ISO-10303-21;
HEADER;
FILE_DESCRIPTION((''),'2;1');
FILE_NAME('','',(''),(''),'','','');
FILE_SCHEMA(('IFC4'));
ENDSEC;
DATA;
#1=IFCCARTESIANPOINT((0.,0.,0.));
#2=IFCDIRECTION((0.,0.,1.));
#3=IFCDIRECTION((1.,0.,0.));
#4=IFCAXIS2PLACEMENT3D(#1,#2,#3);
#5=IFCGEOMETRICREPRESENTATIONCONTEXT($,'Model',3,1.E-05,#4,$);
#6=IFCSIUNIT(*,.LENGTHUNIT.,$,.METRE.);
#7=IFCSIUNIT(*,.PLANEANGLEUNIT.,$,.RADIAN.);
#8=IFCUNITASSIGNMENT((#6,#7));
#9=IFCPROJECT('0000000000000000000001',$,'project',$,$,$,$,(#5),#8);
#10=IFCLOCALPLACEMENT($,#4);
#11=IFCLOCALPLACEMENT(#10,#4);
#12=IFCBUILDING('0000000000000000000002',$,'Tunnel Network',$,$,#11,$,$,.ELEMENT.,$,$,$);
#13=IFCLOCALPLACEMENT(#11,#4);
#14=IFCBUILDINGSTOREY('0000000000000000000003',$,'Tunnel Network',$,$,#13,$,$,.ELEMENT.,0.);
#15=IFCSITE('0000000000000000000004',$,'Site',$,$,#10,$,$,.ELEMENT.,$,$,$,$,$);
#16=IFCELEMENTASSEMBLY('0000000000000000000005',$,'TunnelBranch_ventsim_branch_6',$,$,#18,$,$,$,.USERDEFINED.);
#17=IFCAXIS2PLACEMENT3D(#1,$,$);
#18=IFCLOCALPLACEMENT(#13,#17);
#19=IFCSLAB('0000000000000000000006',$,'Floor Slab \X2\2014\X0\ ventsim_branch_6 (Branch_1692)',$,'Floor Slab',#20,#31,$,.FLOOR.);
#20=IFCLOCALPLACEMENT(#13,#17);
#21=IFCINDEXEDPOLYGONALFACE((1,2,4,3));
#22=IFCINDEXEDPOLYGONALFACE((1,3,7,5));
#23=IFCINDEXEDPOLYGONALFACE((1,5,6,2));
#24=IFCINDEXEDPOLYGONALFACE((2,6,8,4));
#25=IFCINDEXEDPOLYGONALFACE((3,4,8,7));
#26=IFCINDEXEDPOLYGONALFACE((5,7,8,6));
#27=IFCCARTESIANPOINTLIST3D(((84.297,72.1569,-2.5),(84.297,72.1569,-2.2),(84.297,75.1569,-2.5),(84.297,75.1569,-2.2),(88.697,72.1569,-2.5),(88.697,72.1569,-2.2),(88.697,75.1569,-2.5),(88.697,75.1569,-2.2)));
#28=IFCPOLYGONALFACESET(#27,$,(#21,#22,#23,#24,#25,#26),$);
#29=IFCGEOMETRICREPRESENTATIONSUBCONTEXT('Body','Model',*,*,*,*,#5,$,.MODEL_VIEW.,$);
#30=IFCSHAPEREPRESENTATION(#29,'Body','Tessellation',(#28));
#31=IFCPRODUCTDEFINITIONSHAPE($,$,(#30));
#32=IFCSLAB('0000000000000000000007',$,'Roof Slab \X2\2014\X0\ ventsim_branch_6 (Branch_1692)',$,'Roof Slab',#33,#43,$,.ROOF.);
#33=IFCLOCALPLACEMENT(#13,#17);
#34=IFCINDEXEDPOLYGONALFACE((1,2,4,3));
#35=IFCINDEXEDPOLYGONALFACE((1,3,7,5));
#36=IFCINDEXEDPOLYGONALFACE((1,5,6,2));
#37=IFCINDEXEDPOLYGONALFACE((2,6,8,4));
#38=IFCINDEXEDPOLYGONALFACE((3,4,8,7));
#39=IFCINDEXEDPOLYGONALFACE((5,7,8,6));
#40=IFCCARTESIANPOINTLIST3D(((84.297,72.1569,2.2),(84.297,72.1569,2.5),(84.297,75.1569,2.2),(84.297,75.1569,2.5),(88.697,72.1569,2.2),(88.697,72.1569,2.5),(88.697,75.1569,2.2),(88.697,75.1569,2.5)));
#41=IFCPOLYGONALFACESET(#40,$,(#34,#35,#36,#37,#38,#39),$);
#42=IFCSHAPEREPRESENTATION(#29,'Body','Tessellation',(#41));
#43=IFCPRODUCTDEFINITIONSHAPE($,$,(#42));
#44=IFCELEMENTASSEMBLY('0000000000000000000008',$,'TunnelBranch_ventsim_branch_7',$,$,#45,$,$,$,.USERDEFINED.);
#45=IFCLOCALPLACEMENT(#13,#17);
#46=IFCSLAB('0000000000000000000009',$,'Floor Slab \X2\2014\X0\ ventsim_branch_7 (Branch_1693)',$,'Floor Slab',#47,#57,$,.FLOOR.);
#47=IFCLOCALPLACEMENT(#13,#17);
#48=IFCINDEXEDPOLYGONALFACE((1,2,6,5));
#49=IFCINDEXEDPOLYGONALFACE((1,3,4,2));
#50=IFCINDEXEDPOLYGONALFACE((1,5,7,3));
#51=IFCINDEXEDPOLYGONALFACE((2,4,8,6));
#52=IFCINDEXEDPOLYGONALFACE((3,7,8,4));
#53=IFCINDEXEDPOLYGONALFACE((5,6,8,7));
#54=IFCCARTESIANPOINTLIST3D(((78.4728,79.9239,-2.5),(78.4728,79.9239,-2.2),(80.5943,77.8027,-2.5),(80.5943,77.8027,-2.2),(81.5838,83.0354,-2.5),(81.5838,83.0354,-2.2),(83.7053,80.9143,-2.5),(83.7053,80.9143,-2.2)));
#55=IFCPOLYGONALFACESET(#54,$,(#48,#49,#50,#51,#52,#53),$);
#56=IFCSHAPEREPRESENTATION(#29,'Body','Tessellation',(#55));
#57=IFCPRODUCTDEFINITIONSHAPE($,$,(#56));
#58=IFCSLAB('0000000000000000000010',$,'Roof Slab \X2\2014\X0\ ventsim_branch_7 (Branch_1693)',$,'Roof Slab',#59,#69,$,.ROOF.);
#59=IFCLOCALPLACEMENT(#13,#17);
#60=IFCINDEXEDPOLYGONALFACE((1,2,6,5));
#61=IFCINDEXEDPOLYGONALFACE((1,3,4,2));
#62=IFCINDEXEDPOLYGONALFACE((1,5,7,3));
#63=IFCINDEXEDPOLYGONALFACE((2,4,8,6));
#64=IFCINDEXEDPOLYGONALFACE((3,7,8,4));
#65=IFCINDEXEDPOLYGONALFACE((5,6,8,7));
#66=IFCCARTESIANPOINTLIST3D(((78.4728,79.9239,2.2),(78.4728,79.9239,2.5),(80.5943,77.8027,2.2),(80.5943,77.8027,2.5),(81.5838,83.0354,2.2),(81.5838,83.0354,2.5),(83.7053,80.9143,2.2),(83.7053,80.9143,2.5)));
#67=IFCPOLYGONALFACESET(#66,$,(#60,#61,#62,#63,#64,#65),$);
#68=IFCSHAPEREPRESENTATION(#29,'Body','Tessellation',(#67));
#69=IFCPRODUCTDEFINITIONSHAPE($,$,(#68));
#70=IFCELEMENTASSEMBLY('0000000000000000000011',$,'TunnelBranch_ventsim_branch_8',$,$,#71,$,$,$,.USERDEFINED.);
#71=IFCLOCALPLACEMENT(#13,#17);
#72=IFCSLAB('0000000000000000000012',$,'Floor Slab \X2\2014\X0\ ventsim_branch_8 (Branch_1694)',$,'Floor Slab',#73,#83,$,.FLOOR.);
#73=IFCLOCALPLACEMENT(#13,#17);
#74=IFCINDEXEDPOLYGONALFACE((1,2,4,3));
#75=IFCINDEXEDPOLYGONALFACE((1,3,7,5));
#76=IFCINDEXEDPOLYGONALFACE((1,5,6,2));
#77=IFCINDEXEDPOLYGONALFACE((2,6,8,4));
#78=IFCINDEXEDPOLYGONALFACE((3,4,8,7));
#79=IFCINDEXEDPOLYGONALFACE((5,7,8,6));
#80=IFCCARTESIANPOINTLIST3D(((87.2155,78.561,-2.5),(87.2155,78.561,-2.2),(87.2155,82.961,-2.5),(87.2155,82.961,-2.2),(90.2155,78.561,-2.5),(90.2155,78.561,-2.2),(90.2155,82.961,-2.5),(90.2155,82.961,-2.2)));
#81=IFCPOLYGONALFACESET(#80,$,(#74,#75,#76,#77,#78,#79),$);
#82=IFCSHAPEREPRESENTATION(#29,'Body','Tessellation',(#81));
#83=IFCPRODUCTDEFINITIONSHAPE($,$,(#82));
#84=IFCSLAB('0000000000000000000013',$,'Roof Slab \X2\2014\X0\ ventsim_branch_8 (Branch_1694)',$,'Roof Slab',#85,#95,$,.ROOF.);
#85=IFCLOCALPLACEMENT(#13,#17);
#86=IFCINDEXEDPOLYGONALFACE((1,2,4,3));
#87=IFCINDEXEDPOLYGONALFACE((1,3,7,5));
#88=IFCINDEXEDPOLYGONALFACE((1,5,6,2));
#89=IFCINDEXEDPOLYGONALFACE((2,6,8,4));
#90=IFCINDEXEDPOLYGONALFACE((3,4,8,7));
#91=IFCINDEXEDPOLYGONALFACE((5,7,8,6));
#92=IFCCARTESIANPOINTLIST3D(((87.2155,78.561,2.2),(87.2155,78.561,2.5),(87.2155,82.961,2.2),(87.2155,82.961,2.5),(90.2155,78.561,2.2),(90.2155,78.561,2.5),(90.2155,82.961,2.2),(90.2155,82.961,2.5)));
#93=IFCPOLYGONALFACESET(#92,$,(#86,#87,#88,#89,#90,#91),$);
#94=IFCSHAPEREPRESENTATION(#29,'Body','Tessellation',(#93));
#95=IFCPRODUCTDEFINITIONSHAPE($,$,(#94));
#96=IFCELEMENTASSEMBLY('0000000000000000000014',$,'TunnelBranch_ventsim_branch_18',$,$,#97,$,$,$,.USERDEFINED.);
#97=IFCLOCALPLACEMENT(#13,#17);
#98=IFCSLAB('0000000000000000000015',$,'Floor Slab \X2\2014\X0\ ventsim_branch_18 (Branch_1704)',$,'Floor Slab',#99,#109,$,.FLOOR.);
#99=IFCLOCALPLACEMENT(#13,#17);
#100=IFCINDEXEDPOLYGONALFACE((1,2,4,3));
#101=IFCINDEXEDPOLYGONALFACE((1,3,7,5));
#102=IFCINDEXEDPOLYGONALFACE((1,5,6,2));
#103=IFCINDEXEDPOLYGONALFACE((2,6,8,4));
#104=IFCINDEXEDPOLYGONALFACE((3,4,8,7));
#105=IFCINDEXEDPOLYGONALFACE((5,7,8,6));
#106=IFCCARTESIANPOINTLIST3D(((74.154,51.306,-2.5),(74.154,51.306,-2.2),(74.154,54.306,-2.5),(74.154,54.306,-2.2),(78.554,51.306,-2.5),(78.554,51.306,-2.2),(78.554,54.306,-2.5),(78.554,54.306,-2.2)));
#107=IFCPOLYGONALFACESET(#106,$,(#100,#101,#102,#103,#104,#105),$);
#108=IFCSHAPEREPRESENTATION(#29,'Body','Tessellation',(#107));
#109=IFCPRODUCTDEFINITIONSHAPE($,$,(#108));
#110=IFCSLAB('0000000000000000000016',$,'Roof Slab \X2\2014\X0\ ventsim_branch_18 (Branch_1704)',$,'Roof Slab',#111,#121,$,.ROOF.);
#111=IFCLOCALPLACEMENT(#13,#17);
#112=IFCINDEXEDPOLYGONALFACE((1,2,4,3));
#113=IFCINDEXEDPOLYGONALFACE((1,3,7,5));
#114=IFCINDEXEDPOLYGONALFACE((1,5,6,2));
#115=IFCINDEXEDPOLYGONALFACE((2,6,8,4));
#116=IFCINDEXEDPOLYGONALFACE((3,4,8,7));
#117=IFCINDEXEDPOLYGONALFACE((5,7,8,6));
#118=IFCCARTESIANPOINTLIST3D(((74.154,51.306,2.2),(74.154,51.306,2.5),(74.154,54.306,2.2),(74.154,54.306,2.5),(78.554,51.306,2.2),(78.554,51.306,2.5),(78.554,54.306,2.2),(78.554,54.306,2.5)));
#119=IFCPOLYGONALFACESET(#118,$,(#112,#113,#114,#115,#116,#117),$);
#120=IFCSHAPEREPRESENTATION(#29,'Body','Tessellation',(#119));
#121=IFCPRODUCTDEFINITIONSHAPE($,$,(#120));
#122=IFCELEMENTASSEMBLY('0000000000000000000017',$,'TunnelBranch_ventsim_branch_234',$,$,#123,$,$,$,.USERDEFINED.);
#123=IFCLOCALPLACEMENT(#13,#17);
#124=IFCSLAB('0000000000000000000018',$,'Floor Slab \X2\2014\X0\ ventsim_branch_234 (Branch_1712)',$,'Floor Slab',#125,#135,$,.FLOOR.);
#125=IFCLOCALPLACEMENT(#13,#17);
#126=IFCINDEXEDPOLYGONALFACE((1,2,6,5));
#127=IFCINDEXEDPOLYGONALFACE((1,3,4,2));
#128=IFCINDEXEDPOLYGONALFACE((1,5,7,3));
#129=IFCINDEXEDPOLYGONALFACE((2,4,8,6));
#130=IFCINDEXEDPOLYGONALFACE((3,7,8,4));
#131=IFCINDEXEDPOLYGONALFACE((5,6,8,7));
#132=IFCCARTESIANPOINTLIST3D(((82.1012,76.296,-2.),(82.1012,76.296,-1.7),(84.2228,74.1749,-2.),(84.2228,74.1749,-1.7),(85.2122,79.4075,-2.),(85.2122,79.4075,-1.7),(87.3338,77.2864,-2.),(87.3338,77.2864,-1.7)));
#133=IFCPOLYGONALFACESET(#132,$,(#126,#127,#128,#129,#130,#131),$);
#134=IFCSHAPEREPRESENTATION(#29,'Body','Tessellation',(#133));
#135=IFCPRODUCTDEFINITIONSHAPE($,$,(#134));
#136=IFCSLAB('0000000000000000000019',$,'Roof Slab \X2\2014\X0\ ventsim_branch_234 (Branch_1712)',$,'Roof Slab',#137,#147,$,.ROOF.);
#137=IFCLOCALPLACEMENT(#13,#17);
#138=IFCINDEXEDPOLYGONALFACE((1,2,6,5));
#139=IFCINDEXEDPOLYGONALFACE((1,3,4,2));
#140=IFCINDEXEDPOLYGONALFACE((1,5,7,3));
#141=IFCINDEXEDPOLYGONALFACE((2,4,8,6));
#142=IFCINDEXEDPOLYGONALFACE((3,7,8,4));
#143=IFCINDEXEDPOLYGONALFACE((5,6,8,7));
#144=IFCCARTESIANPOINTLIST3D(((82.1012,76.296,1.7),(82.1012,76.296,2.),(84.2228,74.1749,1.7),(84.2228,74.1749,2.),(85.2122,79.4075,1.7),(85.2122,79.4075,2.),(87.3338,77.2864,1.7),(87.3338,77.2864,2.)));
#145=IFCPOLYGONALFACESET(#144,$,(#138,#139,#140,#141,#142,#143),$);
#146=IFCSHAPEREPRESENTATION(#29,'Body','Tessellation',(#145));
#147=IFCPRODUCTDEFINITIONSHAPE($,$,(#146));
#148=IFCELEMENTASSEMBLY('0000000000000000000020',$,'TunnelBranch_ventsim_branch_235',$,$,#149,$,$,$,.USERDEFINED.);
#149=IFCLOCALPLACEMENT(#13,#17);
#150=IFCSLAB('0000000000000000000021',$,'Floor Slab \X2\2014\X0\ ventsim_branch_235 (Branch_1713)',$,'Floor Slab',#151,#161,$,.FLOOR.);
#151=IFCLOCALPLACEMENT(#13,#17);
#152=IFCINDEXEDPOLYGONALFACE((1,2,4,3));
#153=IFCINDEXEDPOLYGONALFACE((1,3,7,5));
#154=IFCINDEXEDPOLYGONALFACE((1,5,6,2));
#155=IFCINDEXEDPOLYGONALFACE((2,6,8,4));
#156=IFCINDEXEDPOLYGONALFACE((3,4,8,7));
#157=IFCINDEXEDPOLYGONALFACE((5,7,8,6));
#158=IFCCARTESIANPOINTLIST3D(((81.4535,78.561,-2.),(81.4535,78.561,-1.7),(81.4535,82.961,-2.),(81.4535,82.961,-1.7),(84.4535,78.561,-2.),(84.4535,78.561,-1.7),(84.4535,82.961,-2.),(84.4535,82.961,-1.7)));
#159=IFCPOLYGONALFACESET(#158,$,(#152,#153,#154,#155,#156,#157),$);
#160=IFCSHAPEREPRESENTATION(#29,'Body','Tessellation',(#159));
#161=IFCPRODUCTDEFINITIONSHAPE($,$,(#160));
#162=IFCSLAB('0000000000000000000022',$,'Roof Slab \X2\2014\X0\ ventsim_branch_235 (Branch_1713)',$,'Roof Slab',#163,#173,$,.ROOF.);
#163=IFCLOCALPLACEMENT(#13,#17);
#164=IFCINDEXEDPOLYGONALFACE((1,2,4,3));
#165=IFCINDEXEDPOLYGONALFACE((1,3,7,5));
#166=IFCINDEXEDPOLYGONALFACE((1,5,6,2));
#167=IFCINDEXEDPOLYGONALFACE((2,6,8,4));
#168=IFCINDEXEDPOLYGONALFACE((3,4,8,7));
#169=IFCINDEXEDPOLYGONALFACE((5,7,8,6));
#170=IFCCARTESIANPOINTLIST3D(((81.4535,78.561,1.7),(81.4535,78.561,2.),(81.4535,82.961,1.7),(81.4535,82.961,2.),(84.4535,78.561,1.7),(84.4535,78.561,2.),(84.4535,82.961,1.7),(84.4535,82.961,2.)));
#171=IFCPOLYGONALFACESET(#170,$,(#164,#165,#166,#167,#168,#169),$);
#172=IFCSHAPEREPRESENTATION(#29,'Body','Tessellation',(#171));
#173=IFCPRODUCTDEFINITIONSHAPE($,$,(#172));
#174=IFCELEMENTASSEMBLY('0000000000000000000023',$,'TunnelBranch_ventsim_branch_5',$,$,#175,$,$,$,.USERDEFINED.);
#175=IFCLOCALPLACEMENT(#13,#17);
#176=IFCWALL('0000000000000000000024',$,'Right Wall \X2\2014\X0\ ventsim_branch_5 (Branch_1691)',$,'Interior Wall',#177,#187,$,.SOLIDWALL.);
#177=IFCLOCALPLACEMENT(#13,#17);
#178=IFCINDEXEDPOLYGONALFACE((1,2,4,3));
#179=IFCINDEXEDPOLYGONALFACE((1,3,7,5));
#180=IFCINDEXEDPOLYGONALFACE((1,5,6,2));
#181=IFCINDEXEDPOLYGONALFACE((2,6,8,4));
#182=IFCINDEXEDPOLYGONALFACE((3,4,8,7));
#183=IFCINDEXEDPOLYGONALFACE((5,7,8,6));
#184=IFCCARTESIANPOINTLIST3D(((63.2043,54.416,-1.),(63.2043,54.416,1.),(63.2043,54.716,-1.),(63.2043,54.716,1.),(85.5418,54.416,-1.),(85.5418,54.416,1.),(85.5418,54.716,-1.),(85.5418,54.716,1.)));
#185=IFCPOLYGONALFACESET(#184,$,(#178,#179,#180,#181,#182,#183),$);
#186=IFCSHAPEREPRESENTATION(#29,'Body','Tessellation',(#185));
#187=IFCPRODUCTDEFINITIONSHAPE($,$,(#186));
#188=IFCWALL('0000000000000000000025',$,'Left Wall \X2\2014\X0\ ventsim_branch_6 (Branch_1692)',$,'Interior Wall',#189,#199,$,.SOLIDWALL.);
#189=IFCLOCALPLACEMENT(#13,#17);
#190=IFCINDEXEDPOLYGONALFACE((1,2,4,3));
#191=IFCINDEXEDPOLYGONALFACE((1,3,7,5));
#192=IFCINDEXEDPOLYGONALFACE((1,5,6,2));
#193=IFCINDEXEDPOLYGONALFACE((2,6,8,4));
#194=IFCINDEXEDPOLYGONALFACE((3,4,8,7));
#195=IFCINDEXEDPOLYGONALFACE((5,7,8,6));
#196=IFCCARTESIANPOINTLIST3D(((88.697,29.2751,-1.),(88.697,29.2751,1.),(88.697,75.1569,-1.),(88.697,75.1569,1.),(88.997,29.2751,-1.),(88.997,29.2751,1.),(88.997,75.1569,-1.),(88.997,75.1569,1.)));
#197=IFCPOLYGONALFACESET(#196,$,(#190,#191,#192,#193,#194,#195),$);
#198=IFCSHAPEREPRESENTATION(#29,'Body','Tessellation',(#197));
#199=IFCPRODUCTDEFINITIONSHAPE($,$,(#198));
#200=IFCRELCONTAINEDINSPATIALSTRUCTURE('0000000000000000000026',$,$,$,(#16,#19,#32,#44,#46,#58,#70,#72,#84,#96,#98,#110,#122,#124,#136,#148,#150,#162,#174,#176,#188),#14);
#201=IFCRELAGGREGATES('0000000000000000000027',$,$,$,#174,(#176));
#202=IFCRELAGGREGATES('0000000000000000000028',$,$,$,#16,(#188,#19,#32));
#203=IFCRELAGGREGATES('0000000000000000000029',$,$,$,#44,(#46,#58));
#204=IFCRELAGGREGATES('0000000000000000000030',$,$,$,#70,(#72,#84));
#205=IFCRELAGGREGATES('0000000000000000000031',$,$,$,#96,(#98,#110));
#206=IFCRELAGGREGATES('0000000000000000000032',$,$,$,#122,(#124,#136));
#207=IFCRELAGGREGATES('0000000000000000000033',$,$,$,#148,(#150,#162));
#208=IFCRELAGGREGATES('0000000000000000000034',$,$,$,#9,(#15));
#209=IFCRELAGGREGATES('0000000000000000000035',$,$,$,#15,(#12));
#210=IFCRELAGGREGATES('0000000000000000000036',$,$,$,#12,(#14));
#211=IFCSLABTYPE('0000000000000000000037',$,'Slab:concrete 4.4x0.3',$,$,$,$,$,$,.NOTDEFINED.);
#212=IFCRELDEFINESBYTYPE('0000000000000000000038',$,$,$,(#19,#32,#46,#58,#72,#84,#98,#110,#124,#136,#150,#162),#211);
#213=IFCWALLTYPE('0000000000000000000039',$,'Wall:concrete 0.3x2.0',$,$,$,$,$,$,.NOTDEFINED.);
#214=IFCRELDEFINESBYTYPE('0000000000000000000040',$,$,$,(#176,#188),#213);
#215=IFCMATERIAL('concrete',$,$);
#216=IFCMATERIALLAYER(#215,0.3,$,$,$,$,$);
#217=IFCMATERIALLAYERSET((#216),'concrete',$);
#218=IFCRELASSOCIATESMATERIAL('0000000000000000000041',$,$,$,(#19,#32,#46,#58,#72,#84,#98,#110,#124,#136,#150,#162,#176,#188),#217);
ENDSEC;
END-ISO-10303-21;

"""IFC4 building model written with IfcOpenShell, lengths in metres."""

from ifc_helpers import new_model, si_unit, frame, origin_with_axes, origin_2d_with_axis, place, context, subcontext, project, spatial, rectangle, extrude, material, layer, layer_set, layer_usage, type_object, element, aggregate, save


model = new_model("IFC4")

# Units and contexts
model_context = context("Model", 3, precision=1e-05, world=origin_with_axes())
body_context = subcontext(model_context, "Body", "Model", "MODEL_VIEW")
ifc_project = project(units=[si_unit("LENGTHUNIT", "METRE"), si_unit("PLANEANGLEUNIT", "RADIAN")], contexts=[model_context])

# Site, building, storey
site_placement = place(None, origin_with_axes())
site = spatial("IfcSite", under=ifc_project, at=site_placement, Name="Site", CompositionType="ELEMENT")
building_placement = place(site_placement, origin_with_axes())
building = spatial("IfcBuilding", under=site, at=building_placement, Name="Tunnel Network", CompositionType="ELEMENT")
storey_placement = place(building_placement, origin_with_axes())
storey = spatial("IfcBuildingStorey", under=building, at=storey_placement, Name="Tunnel Network", CompositionType="ELEMENT", Elevation=0.0)

# Element assemblies, slabs
assembly_1_placement = place(storey_placement, frame((88.847, 75.1569, 0.0), z_axis=(0.0, -1.0, 0.0), x_axis=(-1.0, 0.0, 0.0)))
assembly_1 = element("IfcElementAssembly", 1, at=assembly_1_placement, inside=storey, Name="TunnelBranch_ventsim_branch_6", PredefinedType="USERDEFINED")
ifc_material = material(Name="concrete")
ifc_layer = layer(ifc_material, 0.3)
ifc_layer_set = layer_set([ifc_layer], Name="concrete")
ifc_layer_usage_1 = layer_usage(ifc_layer_set, "AXIS3", "POSITIVE", 0.0)
slab_type = type_object("IfcSlabType", Name="Slab:concrete 4.4x0.3")
slab_1_placement = place(storey_placement, frame((86.497, 75.1569, -2.35), z_axis=(0.0, -1.0, 0.0), x_axis=(-1.0, 0.0, 0.0)))
slab_1 = element("IfcSlab", 2, at=slab_1_placement, inside=storey, type_object=slab_type, material=ifc_layer_usage_1, Name="Floor Slab — ventsim_branch_6 (Branch_1692)", ObjectType="Floor Slab", PredefinedType="FLOOR", context=body_context, shape_type="SweptSolid", body=[
    extrude(rectangle(XDim=4.4, YDim=0.3, at=origin_2d_with_axis()), origin_with_axes(), (0.0, 0.0, 1.0), 3.0),
])
ifc_layer_usage_2 = layer_usage(ifc_layer_set, "AXIS3", "POSITIVE", 0.0)
slab_2_placement = place(storey_placement, frame((86.497, 75.1569, 2.35), z_axis=(0.0, -1.0, 0.0), x_axis=(-1.0, 0.0, 0.0)))
slab_2 = element("IfcSlab", 3, at=slab_2_placement, inside=storey, type_object=slab_type, material=ifc_layer_usage_2, Name="Roof Slab — ventsim_branch_6 (Branch_1692)", ObjectType="Roof Slab", PredefinedType="ROOF", context=body_context, shape_type="SweptSolid", body=[
    extrude(rectangle(XDim=4.4, YDim=0.3, at=origin_2d_with_axis()), origin_with_axes(), (0.0, 0.0, 1.0), 3.0),
])
assembly_2_placement = place(storey_placement, frame((81.6898, 83.1415, 0.0), z_axis=(0.707168, -0.707045, 0.0), x_axis=(-0.707045, -0.707168, 0.0)))
assembly_2 = element("IfcElementAssembly", 4, at=assembly_2_placement, inside=storey, Name="TunnelBranch_ventsim_branch_7", PredefinedType="USERDEFINED")
ifc_layer_usage_3 = layer_usage(ifc_layer_set, "AXIS3", "POSITIVE", 0.0)
slab_3_placement = place(storey_placement, frame((80.0283, 81.4796, -2.35), z_axis=(0.707168, -0.707045, 0.0), x_axis=(-0.707045, -0.707168, 0.0)))
slab_3 = element("IfcSlab", 5, at=slab_3_placement, inside=storey, type_object=slab_type, material=ifc_layer_usage_3, Name="Floor Slab — ventsim_branch_7 (Branch_1693)", ObjectType="Floor Slab", PredefinedType="FLOOR", context=body_context, shape_type="SweptSolid", body=[
    extrude(rectangle(XDim=4.4, YDim=0.3, at=origin_2d_with_axis()), origin_with_axes(), (0.0, 0.0, 1.0), 3.0),
])
ifc_layer_usage_4 = layer_usage(ifc_layer_set, "AXIS3", "POSITIVE", 0.0)
slab_4_placement = place(storey_placement, frame((80.0283, 81.4796, 2.35), z_axis=(0.707168, -0.707045, 0.0), x_axis=(-0.707045, -0.707168, 0.0)))
slab_4 = element("IfcSlab", 6, at=slab_4_placement, inside=storey, type_object=slab_type, material=ifc_layer_usage_4, Name="Roof Slab — ventsim_branch_7 (Branch_1693)", ObjectType="Roof Slab", PredefinedType="ROOF", context=body_context, shape_type="SweptSolid", body=[
    extrude(rectangle(XDim=4.4, YDim=0.3, at=origin_2d_with_axis()), origin_with_axes(), (0.0, 0.0, 1.0), 3.0),
])
assembly_3_placement = place(storey_placement, frame((89.9661, 78.411, 0.0), z_axis=(-1.0, 0.0, 0.0), x_axis=(0.0, 1.0, 0.0)))
assembly_3 = element("IfcElementAssembly", 7, at=assembly_3_placement, inside=storey, Name="TunnelBranch_ventsim_branch_8", PredefinedType="USERDEFINED")
ifc_layer_usage_5 = layer_usage(ifc_layer_set, "AXIS3", "POSITIVE", 0.0)
slab_5_placement = place(storey_placement, frame((90.2155, 80.761, -2.35), z_axis=(-1.0, 0.0, 0.0), x_axis=(0.0, 1.0, 0.0)))
slab_5 = element("IfcSlab", 8, at=slab_5_placement, inside=storey, type_object=slab_type, material=ifc_layer_usage_5, Name="Floor Slab — ventsim_branch_8 (Branch_1694)", ObjectType="Floor Slab", PredefinedType="FLOOR", context=body_context, shape_type="SweptSolid", body=[
    extrude(rectangle(XDim=4.4, YDim=0.3, at=origin_2d_with_axis()), origin_with_axes(), (0.0, 0.0, 1.0), 3.0),
])
ifc_layer_usage_6 = layer_usage(ifc_layer_set, "AXIS3", "POSITIVE", 0.0)
slab_6_placement = place(storey_placement, frame((90.2155, 80.761, 2.35), z_axis=(-1.0, 0.0, 0.0), x_axis=(0.0, 1.0, 0.0)))
slab_6 = element("IfcSlab", 9, at=slab_6_placement, inside=storey, type_object=slab_type, material=ifc_layer_usage_6, Name="Roof Slab — ventsim_branch_8 (Branch_1694)", ObjectType="Roof Slab", PredefinedType="ROOF", context=body_context, shape_type="SweptSolid", body=[
    extrude(rectangle(XDim=4.4, YDim=0.3, at=origin_2d_with_axis()), origin_with_axes(), (0.0, 0.0, 1.0), 3.0),
])
assembly_4_placement = place(storey_placement, frame((78.704, 54.306, 0.0), z_axis=(0.0, -1.0, 0.0), x_axis=(-1.0, 0.0, 0.0)))
assembly_4 = element("IfcElementAssembly", 10, at=assembly_4_placement, inside=storey, Name="TunnelBranch_ventsim_branch_18", PredefinedType="USERDEFINED")
ifc_layer_usage_7 = layer_usage(ifc_layer_set, "AXIS3", "POSITIVE", 0.0)
slab_7_placement = place(storey_placement, frame((76.354, 54.306, -2.35), z_axis=(0.0, -1.0, 0.0), x_axis=(-1.0, 0.0, 0.0)))
slab_7 = element("IfcSlab", 11, at=slab_7_placement, inside=storey, type_object=slab_type, material=ifc_layer_usage_7, Name="Floor Slab — ventsim_branch_18 (Branch_1704)", ObjectType="Floor Slab", PredefinedType="FLOOR", context=body_context, shape_type="SweptSolid", body=[
    extrude(rectangle(XDim=4.4, YDim=0.3, at=origin_2d_with_axis()), origin_with_axes(), (0.0, 0.0, 1.0), 3.0),
])
ifc_layer_usage_8 = layer_usage(ifc_layer_set, "AXIS3", "POSITIVE", 0.0)
slab_8_placement = place(storey_placement, frame((76.354, 54.306, 2.35), z_axis=(0.0, -1.0, 0.0), x_axis=(-1.0, 0.0, 0.0)))
slab_8 = element("IfcSlab", 12, at=slab_8_placement, inside=storey, type_object=slab_type, material=ifc_layer_usage_8, Name="Roof Slab — ventsim_branch_18 (Branch_1704)", ObjectType="Roof Slab", PredefinedType="ROOF", context=body_context, shape_type="SweptSolid", body=[
    extrude(rectangle(XDim=4.4, YDim=0.3, at=origin_2d_with_axis()), origin_with_axes(), (0.0, 0.0, 1.0), 3.0),
])
assembly_5_placement = place(storey_placement, frame((84.1167, 74.0688, 0.0), z_axis=(-0.707168, 0.707045, 0.0), x_axis=(0.707045, 0.707168, 0.0)))
assembly_5 = element("IfcElementAssembly", 13, at=assembly_5_placement, inside=storey, Name="TunnelBranch_ventsim_branch_234", PredefinedType="USERDEFINED")
ifc_layer_usage_9 = layer_usage(ifc_layer_set, "AXIS3", "POSITIVE", 0.0)
slab_9_placement = place(storey_placement, frame((85.7783, 75.7306, -1.85), z_axis=(-0.707168, 0.707045, 0.0), x_axis=(0.707045, 0.707168, 0.0)))
slab_9 = element("IfcSlab", 14, at=slab_9_placement, inside=storey, type_object=slab_type, material=ifc_layer_usage_9, Name="Floor Slab — ventsim_branch_234 (Branch_1712)", ObjectType="Floor Slab", PredefinedType="FLOOR", context=body_context, shape_type="SweptSolid", body=[
    extrude(rectangle(XDim=4.4, YDim=0.3, at=origin_2d_with_axis()), origin_with_axes(), (0.0, 0.0, 1.0), 3.0),
])
ifc_layer_usage_10 = layer_usage(ifc_layer_set, "AXIS3", "POSITIVE", 0.0)
slab_10_placement = place(storey_placement, frame((85.7783, 75.7306, 1.85), z_axis=(-0.707168, 0.707045, 0.0), x_axis=(0.707045, 0.707168, 0.0)))
slab_10 = element("IfcSlab", 15, at=slab_10_placement, inside=storey, type_object=slab_type, material=ifc_layer_usage_10, Name="Roof Slab — ventsim_branch_234 (Branch_1712)", ObjectType="Roof Slab", PredefinedType="ROOF", context=body_context, shape_type="SweptSolid", body=[
    extrude(rectangle(XDim=4.4, YDim=0.3, at=origin_2d_with_axis()), origin_with_axes(), (0.0, 0.0, 1.0), 3.0),
])
assembly_6_placement = place(storey_placement, frame((84.5586, 78.411, 0.0), z_axis=(-1.0, 0.0, 0.0), x_axis=(0.0, 1.0, 0.0)))
assembly_6 = element("IfcElementAssembly", 16, at=assembly_6_placement, inside=storey, Name="TunnelBranch_ventsim_branch_235", PredefinedType="USERDEFINED")
ifc_layer_usage_11 = layer_usage(ifc_layer_set, "AXIS3", "POSITIVE", 0.0)
slab_11_placement = place(storey_placement, frame((84.4535, 80.761, -1.85), z_axis=(-1.0, 0.0, 0.0), x_axis=(0.0, 1.0, 0.0)))
slab_11 = element("IfcSlab", 17, at=slab_11_placement, inside=storey, type_object=slab_type, material=ifc_layer_usage_11, Name="Floor Slab — ventsim_branch_235 (Branch_1713)", ObjectType="Floor Slab", PredefinedType="FLOOR", context=body_context, shape_type="SweptSolid", body=[
    extrude(rectangle(XDim=4.4, YDim=0.3, at=origin_2d_with_axis()), origin_with_axes(), (0.0, 0.0, 1.0), 3.0),
])
ifc_layer_usage_12 = layer_usage(ifc_layer_set, "AXIS3", "POSITIVE", 0.0)
slab_12_placement = place(storey_placement, frame((84.4535, 80.761, 1.85), z_axis=(-1.0, 0.0, 0.0), x_axis=(0.0, 1.0, 0.0)))
slab_12 = element("IfcSlab", 18, at=slab_12_placement, inside=storey, type_object=slab_type, material=ifc_layer_usage_12, Name="Roof Slab — ventsim_branch_235 (Branch_1713)", ObjectType="Roof Slab", PredefinedType="ROOF", context=body_context, shape_type="SweptSolid", body=[
    extrude(rectangle(XDim=4.4, YDim=0.3, at=origin_2d_with_axis()), origin_with_axes(), (0.0, 0.0, 1.0), 3.0),
])

# Element assembly, wall
assembly_7_placement = place(storey_placement, frame((91.0006, 49.866, 0.0), z_axis=(-1.0, 0.0, 0.0), x_axis=(0.0, 1.0, 0.0)))
assembly_7 = element("IfcElementAssembly", 19, at=assembly_7_placement, inside=storey, Name="TunnelBranch_ventsim_branch_5", PredefinedType="USERDEFINED")
ifc_layer_usage_13 = layer_usage(ifc_layer_set, "AXIS2", "POSITIVE", 0.0)
wall_type = type_object("IfcWallType", Name="Wall:concrete 0.3x2.0")
wall_1_placement = place(storey_placement, frame((85.5418, 54.566, 0.0), z_axis=(-1.0, 0.0, 0.0), x_axis=(0.0, 1.0, 0.0)))
wall_1 = element("IfcWall", 20, at=wall_1_placement, inside=storey, type_object=wall_type, material=ifc_layer_usage_13, Name="Right Wall — ventsim_branch_5 (Branch_1691)", ObjectType="Interior Wall", PredefinedType="SOLIDWALL", context=body_context, shape_type="SweptSolid", body=[
    extrude(rectangle(XDim=0.3, YDim=2.0, at=origin_2d_with_axis()), origin_with_axes(), (0.0, 0.0, 1.0), 22.3375),
])
aggregate(assembly_7, [wall_1])

# Wall
ifc_layer_usage_14 = layer_usage(ifc_layer_set, "AXIS2", "POSITIVE", 0.0)
wall_2_placement = place(storey_placement, frame((88.847, 75.1569, 0.0), z_axis=(0.0, -1.0, 0.0), x_axis=(-1.0, 0.0, 0.0)))
wall_2 = element("IfcWall", 21, at=wall_2_placement, inside=storey, type_object=wall_type, material=ifc_layer_usage_14, Name="Left Wall — ventsim_branch_6 (Branch_1692)", ObjectType="Interior Wall", PredefinedType="SOLIDWALL", context=body_context, shape_type="SweptSolid", body=[
    extrude(rectangle(XDim=0.3, YDim=2.0, at=origin_2d_with_axis()), origin_with_axes(), (0.0, 0.0, 1.0), 45.8817),
])
aggregate(assembly_1, [wall_2, slab_1, slab_2])
aggregate(assembly_2, [slab_3, slab_4])
aggregate(assembly_3, [slab_5, slab_6])
aggregate(assembly_4, [slab_7, slab_8])
aggregate(assembly_5, [slab_9, slab_10])
aggregate(assembly_6, [slab_11, slab_12])

save(model, "model.ifc")
